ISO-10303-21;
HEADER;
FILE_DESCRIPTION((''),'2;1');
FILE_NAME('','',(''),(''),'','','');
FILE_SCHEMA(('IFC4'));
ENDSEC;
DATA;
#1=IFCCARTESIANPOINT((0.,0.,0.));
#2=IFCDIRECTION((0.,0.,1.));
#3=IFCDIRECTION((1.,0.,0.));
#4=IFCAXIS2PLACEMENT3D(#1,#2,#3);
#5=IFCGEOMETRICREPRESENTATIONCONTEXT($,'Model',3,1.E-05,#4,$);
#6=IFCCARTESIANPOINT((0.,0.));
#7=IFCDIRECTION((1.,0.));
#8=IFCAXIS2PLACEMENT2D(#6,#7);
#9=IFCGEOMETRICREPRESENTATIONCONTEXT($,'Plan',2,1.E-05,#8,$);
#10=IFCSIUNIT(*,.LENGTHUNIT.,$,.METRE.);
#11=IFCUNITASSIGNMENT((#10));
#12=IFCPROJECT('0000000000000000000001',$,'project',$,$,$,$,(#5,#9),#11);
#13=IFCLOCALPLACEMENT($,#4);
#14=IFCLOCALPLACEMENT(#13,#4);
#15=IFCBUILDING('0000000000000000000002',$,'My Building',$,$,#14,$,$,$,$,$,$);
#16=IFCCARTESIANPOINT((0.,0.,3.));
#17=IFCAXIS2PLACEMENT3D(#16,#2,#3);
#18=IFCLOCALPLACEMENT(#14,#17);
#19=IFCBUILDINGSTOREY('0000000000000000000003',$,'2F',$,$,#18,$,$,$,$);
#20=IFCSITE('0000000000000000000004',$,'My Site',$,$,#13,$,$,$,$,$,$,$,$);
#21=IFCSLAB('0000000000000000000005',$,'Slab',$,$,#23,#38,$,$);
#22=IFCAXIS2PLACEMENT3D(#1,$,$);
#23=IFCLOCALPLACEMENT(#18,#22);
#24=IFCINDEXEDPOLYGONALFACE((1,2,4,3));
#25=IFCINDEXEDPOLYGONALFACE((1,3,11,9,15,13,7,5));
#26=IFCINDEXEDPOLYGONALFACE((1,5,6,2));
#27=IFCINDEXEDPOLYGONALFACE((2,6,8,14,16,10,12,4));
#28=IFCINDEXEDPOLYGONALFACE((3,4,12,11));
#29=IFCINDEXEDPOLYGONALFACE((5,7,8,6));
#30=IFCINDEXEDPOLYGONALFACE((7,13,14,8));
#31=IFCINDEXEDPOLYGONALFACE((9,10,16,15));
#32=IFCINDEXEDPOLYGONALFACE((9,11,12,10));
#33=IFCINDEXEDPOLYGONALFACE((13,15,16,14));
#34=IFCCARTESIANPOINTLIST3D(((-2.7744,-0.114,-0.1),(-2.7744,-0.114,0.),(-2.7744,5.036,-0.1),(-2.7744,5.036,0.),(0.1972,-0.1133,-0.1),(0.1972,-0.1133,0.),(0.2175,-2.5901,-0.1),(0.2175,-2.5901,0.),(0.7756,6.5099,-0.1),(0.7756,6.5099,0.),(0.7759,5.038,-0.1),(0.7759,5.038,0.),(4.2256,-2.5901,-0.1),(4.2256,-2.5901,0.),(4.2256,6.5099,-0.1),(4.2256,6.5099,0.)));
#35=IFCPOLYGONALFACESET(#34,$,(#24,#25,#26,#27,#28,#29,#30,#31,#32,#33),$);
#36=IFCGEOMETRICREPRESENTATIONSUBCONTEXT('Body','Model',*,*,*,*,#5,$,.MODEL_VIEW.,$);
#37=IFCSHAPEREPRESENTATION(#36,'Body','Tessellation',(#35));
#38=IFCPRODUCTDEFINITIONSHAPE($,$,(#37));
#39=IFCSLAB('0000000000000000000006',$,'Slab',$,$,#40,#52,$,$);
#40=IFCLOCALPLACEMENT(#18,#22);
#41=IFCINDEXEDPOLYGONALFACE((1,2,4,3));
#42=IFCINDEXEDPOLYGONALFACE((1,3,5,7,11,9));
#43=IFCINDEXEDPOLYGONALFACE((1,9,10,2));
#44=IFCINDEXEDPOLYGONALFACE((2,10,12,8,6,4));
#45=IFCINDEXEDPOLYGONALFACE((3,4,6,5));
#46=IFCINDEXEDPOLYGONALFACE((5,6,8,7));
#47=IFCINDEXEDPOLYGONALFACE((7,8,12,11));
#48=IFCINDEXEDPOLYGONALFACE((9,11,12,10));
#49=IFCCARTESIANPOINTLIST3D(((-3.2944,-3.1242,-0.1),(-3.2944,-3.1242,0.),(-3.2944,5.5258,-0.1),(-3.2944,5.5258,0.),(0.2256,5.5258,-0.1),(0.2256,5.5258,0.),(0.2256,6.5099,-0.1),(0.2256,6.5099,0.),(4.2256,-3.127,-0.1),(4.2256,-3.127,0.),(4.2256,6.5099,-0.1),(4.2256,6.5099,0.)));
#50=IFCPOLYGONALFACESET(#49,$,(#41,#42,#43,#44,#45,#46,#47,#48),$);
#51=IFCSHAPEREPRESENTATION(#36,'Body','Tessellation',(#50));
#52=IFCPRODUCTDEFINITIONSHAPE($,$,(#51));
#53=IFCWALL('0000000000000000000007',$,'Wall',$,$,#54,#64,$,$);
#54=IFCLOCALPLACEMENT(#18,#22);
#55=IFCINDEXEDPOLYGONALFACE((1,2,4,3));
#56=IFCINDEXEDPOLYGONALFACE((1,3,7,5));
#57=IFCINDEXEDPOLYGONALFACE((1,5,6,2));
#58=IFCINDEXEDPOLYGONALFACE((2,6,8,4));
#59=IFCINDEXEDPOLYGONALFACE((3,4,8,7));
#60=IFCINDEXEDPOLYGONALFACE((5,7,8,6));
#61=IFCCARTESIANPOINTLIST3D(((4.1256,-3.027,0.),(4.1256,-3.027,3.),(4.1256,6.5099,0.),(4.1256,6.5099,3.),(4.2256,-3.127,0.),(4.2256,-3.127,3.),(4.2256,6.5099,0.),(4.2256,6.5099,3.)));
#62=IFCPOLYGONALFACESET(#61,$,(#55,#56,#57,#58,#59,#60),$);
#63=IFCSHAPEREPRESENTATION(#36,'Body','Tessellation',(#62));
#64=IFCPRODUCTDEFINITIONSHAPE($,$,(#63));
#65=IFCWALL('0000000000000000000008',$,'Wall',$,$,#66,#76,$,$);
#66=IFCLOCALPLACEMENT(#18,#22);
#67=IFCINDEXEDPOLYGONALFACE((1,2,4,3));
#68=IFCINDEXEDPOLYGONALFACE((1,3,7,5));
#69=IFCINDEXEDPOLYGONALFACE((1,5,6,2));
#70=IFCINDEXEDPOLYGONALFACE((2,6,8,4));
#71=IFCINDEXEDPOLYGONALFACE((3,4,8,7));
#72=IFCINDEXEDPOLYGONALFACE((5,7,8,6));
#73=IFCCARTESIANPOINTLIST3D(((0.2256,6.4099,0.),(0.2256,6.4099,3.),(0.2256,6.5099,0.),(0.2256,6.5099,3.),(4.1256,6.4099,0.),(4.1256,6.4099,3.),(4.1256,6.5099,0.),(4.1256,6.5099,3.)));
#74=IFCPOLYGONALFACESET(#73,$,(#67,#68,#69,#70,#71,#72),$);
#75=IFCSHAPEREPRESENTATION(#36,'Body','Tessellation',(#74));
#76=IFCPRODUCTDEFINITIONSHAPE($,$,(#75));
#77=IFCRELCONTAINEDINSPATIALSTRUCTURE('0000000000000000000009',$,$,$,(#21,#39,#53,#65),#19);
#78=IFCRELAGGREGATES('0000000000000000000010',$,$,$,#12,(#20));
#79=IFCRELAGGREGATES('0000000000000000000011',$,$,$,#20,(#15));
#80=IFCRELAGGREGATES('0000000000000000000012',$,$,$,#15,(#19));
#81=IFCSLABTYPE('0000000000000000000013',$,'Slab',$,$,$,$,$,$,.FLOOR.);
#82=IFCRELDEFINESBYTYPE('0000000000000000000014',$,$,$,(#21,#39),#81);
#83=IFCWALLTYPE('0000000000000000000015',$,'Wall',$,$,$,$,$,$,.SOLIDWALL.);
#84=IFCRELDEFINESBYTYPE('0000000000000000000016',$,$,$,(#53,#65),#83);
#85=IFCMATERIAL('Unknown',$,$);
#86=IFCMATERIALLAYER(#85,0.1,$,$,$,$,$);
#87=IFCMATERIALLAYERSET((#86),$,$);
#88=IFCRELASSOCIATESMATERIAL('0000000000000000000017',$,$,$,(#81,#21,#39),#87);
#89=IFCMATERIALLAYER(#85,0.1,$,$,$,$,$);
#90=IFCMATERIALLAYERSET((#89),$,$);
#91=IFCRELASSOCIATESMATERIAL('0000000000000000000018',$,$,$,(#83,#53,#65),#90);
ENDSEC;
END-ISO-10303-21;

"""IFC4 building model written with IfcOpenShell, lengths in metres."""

from ifc_helpers import new_model, si_unit, frame, origin_with_axes, origin_2d_with_axis, place, context, subcontext, project, spatial, line, indexed_curve, outline, extrude, material, layer, layer_set, layer_usage, type_object, element, save


model = new_model("IFC4")

# Units and contexts
model_context = context("Model", 3, precision=1e-05, world=origin_with_axes())
plan_context = context("Plan", 2, precision=1e-05, world=origin_2d_with_axis())
body_context_1 = subcontext(model_context, "Body", "Model", "MODEL_VIEW")
ifc_project = project(units=[si_unit("LENGTHUNIT", "METRE")], contexts=[model_context, plan_context])

# Site, building, storey
site_placement = place(None, origin_with_axes())
site = spatial("IfcSite", under=ifc_project, at=site_placement, Name="My Site")
building_placement = place(site_placement, origin_with_axes())
building = spatial("IfcBuilding", under=site, at=building_placement, Name="My Building")
storey_placement = place(building_placement, frame((0.0, 0.0, 3.0), z_axis=(0.0, 0.0, 1.0), x_axis=(1.0, 0.0, 0.0)))
storey = spatial("IfcBuildingStorey", under=building, at=storey_placement, Name="2F")

# Slabs
ifc_material = material(Name="Unknown")
ifc_layer_1 = layer(ifc_material, 0.1)
ifc_layer_set_1 = layer_set([ifc_layer_1])
ifc_layer_usage_1 = layer_usage(ifc_layer_set_1, "AXIS3", "POSITIVE", -0.1)
slab_type = type_object("IfcSlabType", Name="Slab", PredefinedType="FLOOR", material=ifc_layer_set_1)
slab_1_placement = place(storey_placement, frame((4.2256, -2.5901, 0.0), z_axis=(0.0, 0.0, 1.0), x_axis=(1.0, 0.0, 0.0)))
element("IfcSlab", 1, at=slab_1_placement, inside=storey, type_object=slab_type, material=ifc_layer_usage_1, Name="Slab", context=body_context_1, shape_type="SweptSolid", body=[
    extrude(outline(indexed_curve([(0.0, 0.0), (0.0, 9.1), (-3.45, 9.1), (-3.4497, 7.6281), (-7.0, 7.6261), (-7.0, 2.4761), (-4.0284, 2.4768), (-4.0081, 0.0), (0.0, 0.0)])), frame((0.0, 0.0, -0.1), z_axis=(0.0, 0.0, 1.0), x_axis=(1.0, 0.0, 0.0)), (0.0, 0.0, 1.0), 0.1),
])
ifc_layer_usage_2 = layer_usage(ifc_layer_set_1, "AXIS3", "POSITIVE", -0.1)
slab_2_placement = place(storey_placement, frame((4.2256, -3.127, 0.0), z_axis=(0.0, 0.0, 1.0), x_axis=(1.0, 0.0, 0.0)))
element("IfcSlab", 2, at=slab_2_placement, inside=storey, type_object=slab_type, material=ifc_layer_usage_2, Name="Slab", context=body_context_1, shape_type="SweptSolid", body=[
    extrude(outline(indexed_curve([(0.0, 0.0), (0.0, 9.6369), (-4.0, 9.6369), (-4.0, 8.6528), (-7.52, 8.6528), (-7.52, 0.0028), (0.0, 0.0)])), frame((0.0, 0.0, -0.1), z_axis=(0.0, 0.0, 1.0), x_axis=(1.0, 0.0, 0.0)), (0.0, 0.0, 1.0), 0.1),
])

# Walls
ifc_layer_2 = layer(ifc_material, 0.1)
ifc_layer_set_2 = layer_set([ifc_layer_2])
ifc_layer_usage_3 = layer_usage(ifc_layer_set_2, "AXIS2", "POSITIVE", 0.0)
wall_type = type_object("IfcWallType", Name="Wall", PredefinedType="SOLIDWALL", material=ifc_layer_set_2)
wall_1_placement = place(storey_placement, frame((4.2256, -3.127, 0.0), z_axis=(0.0, 0.0, 1.0), x_axis=(0.0, 1.0, 0.0)))
element("IfcWall", 3, at=wall_1_placement, inside=storey, type_object=wall_type, material=ifc_layer_usage_3, Name="Wall", context=body_context_1, shape_type="SweptSolid", body=[
    extrude(outline(indexed_curve([(0.0, 0.0), (0.1, 0.1), (9.6369, 0.1), (9.6369, 0.0)], segments=[line(1, 2, 3, 4, 1)])), origin_with_axes(), (0.0, 0.0, 1.0), 3.0),
])
ifc_layer_usage_4 = layer_usage(ifc_layer_set_2, "AXIS2", "POSITIVE", 0.0)
wall_2_placement = place(storey_placement, frame((4.1256, 6.5099, 0.0), z_axis=(0.0, 0.0, 1.0), x_axis=(-1.0, 0.0, 0.0)))
element("IfcWall", 4, at=wall_2_placement, inside=storey, type_object=wall_type, material=ifc_layer_usage_4, Name="Wall", context=body_context_1, shape_type="SweptSolid", body=[
    extrude(outline(indexed_curve([(0.0, 0.0), (0.0, 0.1), (3.9, 0.1), (3.9, 0.0)], segments=[line(1, 2, 3, 4, 1)])), origin_with_axes(), (0.0, 0.0, 1.0), 3.0),
])

save(model, "model.ifc")
